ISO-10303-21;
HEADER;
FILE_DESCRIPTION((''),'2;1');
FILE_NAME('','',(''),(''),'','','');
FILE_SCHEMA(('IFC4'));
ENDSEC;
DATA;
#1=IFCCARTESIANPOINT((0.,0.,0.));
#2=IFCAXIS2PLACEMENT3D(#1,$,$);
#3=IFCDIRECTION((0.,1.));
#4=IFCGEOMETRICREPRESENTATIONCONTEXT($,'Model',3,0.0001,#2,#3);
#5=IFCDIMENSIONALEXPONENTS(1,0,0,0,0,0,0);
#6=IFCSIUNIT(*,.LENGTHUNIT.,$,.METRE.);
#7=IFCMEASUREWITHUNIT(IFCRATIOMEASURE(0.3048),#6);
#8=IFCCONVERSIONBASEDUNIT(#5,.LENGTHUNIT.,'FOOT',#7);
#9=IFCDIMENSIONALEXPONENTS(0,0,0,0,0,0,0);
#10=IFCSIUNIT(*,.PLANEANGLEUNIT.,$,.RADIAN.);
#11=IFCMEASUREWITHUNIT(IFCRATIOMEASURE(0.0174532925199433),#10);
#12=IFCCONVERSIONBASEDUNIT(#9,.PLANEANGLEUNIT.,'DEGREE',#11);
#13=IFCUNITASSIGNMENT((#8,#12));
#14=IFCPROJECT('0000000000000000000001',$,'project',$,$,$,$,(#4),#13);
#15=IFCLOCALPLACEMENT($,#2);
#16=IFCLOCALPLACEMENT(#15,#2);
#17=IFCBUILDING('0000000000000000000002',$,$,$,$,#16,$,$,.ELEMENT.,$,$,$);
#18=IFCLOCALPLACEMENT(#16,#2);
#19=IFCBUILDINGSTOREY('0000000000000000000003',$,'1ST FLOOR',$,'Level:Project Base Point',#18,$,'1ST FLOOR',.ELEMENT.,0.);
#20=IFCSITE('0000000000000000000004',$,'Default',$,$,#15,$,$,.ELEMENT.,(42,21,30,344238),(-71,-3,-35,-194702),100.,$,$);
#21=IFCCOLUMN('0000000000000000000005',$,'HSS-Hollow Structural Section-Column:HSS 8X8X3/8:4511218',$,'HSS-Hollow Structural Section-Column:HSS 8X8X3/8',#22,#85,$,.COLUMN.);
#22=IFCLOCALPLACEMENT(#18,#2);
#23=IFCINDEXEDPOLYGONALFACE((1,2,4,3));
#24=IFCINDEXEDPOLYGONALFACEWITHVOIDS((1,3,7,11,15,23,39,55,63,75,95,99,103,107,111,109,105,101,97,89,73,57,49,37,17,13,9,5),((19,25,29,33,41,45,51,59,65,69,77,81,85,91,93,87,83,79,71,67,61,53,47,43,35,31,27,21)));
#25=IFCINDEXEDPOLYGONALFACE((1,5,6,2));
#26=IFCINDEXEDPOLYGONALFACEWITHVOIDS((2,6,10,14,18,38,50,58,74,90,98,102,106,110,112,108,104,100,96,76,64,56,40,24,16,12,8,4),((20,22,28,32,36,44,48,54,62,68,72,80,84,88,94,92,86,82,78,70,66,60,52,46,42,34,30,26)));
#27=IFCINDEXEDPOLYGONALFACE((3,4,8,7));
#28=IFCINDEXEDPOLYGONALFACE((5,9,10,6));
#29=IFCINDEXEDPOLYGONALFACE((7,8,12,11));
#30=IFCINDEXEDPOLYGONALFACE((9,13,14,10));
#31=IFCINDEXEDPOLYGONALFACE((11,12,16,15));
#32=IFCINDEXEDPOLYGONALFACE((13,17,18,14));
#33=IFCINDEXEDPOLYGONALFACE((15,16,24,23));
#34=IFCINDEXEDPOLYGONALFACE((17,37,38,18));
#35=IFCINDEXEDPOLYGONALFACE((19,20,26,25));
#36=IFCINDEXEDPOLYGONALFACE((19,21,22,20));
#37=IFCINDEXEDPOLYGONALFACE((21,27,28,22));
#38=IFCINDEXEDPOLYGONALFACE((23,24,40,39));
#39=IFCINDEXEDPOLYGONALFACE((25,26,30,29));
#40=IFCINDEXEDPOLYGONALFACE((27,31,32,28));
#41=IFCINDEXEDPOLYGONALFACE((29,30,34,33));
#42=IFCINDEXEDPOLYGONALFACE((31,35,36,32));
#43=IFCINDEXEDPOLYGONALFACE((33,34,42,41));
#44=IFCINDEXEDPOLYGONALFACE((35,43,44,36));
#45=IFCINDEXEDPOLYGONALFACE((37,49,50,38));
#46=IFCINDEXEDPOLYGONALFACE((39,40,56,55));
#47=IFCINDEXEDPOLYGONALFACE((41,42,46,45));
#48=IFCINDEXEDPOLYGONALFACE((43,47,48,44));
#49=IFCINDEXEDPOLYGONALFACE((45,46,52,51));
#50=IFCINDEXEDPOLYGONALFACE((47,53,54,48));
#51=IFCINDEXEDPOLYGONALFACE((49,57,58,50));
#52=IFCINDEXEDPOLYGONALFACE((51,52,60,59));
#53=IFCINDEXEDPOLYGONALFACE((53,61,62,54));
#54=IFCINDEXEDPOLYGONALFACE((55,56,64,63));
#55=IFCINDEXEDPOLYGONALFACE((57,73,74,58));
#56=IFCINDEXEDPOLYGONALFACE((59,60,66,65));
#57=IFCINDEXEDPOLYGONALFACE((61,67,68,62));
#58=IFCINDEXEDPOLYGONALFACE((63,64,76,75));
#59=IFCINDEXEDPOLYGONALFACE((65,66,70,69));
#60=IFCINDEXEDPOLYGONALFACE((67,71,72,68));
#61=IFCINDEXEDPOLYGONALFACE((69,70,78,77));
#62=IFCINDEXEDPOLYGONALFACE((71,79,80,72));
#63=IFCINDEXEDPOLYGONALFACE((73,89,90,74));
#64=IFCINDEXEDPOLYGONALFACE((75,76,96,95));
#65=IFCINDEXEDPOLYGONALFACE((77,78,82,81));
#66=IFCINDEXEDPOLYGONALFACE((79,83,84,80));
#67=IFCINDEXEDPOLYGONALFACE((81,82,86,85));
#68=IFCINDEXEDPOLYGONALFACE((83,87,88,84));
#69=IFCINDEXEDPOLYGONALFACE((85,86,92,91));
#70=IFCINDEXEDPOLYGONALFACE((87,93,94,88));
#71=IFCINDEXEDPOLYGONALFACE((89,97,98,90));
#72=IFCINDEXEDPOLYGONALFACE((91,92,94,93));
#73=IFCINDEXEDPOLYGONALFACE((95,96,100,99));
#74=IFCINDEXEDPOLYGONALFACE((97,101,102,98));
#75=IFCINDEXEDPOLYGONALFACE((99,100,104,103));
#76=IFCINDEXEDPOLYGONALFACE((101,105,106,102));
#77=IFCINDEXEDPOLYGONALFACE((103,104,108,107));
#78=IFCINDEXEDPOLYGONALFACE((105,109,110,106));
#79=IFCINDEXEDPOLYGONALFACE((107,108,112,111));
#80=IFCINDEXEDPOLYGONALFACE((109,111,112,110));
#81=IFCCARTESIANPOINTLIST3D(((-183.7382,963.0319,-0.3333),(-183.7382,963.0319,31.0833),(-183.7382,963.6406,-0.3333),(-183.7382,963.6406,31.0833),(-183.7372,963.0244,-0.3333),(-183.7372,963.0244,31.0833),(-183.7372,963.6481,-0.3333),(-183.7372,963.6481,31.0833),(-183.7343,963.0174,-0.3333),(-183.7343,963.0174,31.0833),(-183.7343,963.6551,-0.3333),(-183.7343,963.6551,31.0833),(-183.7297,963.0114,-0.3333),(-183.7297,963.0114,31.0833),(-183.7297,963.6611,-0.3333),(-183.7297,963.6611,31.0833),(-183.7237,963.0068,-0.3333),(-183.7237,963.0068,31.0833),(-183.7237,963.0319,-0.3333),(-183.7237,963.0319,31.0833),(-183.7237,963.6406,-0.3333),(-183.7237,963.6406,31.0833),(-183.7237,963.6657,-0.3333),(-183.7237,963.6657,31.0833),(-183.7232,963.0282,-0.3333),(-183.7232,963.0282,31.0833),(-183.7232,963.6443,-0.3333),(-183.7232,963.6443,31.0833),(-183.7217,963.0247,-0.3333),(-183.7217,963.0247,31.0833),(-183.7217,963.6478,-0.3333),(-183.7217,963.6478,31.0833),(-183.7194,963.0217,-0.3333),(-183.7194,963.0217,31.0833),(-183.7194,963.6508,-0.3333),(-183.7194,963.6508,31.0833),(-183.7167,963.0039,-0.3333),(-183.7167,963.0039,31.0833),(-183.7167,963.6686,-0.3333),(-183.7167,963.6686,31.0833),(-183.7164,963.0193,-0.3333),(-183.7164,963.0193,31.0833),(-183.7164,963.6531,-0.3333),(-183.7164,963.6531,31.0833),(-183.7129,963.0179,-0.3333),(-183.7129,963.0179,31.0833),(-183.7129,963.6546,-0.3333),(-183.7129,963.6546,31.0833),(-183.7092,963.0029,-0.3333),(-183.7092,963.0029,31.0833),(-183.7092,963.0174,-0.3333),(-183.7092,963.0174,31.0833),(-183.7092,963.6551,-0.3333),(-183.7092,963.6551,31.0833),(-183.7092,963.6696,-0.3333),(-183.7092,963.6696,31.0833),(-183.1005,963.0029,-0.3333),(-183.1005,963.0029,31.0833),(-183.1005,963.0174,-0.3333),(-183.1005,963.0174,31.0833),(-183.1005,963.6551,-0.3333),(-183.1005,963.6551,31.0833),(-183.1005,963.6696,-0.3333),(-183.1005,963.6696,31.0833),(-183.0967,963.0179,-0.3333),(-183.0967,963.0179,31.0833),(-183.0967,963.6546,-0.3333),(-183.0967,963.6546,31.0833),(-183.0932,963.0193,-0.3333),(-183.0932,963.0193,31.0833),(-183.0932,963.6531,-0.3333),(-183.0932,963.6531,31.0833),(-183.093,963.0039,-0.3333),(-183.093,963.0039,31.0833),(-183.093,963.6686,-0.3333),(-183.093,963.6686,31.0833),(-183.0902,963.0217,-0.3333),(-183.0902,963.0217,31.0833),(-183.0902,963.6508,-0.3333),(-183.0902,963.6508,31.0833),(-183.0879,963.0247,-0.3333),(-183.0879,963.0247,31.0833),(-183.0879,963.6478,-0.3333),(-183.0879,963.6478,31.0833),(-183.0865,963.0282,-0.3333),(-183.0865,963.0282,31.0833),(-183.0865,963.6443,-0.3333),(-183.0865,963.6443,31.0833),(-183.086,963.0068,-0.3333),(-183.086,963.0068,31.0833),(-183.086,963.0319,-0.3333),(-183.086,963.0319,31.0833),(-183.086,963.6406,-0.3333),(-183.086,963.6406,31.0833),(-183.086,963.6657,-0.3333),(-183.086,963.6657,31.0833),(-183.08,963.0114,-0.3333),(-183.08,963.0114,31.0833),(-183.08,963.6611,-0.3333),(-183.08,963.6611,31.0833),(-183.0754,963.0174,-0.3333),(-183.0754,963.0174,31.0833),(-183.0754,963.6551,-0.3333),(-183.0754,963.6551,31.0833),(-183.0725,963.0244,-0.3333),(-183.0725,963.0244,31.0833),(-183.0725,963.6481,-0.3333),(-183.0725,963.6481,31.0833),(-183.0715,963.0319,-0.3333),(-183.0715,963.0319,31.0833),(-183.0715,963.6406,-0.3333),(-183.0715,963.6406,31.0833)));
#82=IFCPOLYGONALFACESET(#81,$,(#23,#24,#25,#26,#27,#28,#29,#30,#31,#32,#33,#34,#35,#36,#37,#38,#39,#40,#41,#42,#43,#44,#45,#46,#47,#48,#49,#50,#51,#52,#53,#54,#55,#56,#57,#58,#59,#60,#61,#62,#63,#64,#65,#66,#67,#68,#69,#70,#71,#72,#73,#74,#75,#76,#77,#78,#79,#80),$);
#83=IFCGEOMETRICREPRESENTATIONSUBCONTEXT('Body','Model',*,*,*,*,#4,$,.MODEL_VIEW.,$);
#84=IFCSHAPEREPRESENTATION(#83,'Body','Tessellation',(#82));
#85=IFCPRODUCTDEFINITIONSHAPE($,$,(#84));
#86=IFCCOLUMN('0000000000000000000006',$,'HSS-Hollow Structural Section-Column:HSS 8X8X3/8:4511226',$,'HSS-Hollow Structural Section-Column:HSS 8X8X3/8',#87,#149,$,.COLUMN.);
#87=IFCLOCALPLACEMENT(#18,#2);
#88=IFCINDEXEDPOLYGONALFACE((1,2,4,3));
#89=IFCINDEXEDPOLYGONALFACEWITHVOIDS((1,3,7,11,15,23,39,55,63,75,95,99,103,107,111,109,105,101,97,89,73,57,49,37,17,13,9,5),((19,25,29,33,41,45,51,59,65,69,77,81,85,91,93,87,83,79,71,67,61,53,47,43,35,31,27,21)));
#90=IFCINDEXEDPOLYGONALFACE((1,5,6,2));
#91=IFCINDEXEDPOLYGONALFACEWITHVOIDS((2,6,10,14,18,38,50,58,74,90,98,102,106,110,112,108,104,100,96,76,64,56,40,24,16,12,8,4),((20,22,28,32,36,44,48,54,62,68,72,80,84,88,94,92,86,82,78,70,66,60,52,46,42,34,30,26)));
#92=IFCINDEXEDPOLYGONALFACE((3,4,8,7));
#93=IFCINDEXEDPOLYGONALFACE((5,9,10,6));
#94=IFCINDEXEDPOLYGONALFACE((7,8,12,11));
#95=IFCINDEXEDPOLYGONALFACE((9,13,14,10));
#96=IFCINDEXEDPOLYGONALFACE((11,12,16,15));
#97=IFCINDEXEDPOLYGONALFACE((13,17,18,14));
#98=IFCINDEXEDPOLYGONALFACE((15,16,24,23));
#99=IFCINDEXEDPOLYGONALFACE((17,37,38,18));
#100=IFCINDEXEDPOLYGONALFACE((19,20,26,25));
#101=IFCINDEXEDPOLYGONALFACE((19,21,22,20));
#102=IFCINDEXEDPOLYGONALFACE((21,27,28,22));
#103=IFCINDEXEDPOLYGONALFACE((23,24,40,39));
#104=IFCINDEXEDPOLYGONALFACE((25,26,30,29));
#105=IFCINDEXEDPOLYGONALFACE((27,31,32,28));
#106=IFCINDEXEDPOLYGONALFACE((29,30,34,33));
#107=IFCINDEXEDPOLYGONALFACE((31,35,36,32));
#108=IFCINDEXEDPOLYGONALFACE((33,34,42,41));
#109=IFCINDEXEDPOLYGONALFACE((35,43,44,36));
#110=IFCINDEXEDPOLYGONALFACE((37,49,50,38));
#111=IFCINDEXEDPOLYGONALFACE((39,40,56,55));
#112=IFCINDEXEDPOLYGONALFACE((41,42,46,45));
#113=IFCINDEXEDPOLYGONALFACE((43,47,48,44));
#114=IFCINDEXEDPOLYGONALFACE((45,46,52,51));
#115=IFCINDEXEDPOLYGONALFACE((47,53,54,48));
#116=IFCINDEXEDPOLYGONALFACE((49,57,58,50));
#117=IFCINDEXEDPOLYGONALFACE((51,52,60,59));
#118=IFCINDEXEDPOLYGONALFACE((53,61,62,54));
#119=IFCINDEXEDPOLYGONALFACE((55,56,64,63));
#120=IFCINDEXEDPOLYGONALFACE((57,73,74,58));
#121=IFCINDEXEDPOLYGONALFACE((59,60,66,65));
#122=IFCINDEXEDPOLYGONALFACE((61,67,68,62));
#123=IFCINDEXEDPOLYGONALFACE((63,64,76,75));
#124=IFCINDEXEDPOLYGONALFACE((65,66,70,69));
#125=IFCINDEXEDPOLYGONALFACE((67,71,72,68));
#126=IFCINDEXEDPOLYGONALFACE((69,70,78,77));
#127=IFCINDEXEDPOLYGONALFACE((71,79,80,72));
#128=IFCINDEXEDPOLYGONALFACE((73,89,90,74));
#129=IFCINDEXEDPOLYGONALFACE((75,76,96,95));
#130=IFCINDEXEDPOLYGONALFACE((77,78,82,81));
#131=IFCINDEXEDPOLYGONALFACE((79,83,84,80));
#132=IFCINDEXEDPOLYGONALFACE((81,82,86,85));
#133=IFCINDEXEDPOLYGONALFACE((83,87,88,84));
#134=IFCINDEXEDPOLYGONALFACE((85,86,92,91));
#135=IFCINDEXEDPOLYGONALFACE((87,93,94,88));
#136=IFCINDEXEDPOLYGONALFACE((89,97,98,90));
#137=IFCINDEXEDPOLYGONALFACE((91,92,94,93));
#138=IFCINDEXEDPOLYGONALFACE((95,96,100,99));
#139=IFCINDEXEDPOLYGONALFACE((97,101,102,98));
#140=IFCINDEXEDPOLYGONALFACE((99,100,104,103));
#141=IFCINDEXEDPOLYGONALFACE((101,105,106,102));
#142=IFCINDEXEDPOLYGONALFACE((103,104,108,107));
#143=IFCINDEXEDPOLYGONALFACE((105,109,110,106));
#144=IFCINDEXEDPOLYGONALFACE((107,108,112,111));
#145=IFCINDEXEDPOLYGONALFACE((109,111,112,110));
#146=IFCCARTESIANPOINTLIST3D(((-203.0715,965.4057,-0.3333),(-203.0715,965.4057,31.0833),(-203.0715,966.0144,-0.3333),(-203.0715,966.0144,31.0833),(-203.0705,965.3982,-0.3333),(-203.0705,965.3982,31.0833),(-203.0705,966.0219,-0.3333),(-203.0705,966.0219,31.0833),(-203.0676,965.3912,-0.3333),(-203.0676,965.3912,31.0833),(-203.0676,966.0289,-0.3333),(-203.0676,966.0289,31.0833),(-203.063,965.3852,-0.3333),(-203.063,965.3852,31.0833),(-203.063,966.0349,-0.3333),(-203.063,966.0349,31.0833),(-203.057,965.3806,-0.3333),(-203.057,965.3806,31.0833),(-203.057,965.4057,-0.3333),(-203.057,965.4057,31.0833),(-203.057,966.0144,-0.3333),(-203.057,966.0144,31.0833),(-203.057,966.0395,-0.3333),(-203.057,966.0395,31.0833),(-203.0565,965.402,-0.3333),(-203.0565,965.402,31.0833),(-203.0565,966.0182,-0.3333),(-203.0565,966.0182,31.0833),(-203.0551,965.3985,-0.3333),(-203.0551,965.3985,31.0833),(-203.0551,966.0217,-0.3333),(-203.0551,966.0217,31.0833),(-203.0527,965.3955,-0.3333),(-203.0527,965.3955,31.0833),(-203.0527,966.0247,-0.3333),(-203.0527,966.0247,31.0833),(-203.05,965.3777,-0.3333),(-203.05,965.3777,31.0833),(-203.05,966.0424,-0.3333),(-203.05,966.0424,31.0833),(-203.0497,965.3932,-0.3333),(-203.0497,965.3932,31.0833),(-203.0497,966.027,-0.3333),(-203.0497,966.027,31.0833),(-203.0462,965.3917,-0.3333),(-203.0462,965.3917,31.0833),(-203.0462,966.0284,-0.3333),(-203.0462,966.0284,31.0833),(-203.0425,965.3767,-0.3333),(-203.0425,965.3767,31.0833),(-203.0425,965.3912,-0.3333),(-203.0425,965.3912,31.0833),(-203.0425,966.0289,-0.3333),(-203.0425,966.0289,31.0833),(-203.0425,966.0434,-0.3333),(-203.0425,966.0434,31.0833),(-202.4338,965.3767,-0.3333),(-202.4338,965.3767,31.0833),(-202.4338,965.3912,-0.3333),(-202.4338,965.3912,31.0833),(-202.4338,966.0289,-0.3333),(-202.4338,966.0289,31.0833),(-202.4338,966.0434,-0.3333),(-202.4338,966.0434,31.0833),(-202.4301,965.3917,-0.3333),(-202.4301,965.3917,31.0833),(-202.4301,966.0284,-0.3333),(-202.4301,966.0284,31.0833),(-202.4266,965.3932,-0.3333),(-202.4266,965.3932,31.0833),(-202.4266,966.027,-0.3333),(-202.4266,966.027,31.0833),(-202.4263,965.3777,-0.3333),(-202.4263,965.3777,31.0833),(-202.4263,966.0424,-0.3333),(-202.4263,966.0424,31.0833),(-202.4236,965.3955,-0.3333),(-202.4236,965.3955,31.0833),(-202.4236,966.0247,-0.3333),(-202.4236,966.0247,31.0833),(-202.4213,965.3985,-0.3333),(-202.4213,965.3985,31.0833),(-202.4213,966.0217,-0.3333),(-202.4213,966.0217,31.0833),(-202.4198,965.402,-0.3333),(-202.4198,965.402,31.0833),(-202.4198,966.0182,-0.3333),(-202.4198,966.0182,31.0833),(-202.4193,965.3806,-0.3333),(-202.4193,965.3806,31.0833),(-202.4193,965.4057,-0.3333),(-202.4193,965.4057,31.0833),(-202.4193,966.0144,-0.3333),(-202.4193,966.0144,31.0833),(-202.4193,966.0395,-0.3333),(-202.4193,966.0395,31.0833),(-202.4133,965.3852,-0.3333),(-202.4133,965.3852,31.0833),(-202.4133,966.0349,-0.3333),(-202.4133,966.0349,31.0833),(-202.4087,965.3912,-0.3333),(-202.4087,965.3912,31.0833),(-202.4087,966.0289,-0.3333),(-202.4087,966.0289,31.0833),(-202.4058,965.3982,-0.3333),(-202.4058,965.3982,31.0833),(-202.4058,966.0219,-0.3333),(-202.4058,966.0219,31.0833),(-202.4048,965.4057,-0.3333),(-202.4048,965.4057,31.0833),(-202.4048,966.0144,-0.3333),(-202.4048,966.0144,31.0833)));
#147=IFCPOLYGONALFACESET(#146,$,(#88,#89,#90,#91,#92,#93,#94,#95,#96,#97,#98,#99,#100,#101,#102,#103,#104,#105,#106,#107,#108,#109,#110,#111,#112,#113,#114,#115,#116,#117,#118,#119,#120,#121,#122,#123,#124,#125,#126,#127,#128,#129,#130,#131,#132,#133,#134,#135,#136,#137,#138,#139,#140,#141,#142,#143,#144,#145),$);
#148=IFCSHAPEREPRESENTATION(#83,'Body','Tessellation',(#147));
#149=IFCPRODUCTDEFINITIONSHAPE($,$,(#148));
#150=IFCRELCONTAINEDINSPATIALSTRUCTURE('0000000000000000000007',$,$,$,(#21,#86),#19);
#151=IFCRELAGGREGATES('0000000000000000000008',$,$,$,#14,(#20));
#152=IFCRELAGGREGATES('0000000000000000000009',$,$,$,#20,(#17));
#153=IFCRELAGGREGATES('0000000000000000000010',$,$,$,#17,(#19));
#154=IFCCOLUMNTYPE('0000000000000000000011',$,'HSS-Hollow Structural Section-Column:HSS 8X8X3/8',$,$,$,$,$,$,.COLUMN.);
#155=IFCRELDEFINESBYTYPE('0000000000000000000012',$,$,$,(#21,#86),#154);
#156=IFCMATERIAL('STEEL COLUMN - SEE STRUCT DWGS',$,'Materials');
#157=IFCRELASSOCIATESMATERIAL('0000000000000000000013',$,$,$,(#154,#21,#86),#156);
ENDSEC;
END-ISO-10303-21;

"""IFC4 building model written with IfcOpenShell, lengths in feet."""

from ifc_helpers import new_model, entity, si_unit, converted_unit, direction, frame, frame_2d, origin, place, context, subcontext, project, spatial, polyline, circle_curve, parameter, trimmed, segment, composite_curve, outline, extrude, source, transform, mapped, material, material_profile, profile_set, profile_usage, type_object, type_shapes, element, save


model = new_model("IFC4")

# Units and contexts
model_context = context("Model", 3, precision=0.0001, world=origin(), true_north=direction((0.0, 1.0)))
body_context = subcontext(model_context, "Body", "Model", "MODEL_VIEW")
ifc_project = project(units=[converted_unit("LENGTHUNIT", "FOOT", entity("IfcRatioMeasure", 0.3048), si_unit("LENGTHUNIT", "METRE"), dimensions=[1, 0, 0, 0, 0, 0, 0]), converted_unit("PLANEANGLEUNIT", "DEGREE", entity("IfcRatioMeasure", 0.0174532925199433), si_unit("PLANEANGLEUNIT", "RADIAN"), dimensions=[0, 0, 0, 0, 0, 0, 0])], contexts=[model_context])

# Site, building, storey
site_placement = place(None, origin())
site = spatial("IfcSite", under=ifc_project, at=site_placement, Name="Default", CompositionType="ELEMENT", RefLatitude=(42, 21, 30, 344238), RefLongitude=(-71, -3, -35, -194702), RefElevation=100.0)
building_placement = place(site_placement, origin())
building = spatial("IfcBuilding", under=site, at=building_placement, CompositionType="ELEMENT")
storey_placement = place(building_placement, origin())
storey = spatial("IfcBuildingStorey", under=building, at=storey_placement, Name="1ST FLOOR", ObjectType="Level:Project Base Point", LongName="1ST FLOOR", CompositionType="ELEMENT", Elevation=0.0)

# Columns
ifc_material_1 = material(Name="STEEL COLUMN - SEE STRUCT DWGS", Category="Materials")
ifc_material_profile = material_profile(ifc_material_1, outline(composite_curve([segment(polyline([(-0.3043, -0.3333), (0.3043, -0.3333)]), True, "CONTINUOUS"), segment(trimmed(circle_curve(frame_2d((0.3043, -0.3043), x_axis=(-1.0, 0.0)), 0.029), [parameter(90.0)], [parameter(180.0)], True, "PARAMETER"), True, "CONTINUOUS"), segment(polyline([(0.3333, -0.3043), (0.3333, 0.3043)]), True, "CONTINUOUS"), segment(trimmed(circle_curve(frame_2d((0.3043, 0.3043), x_axis=(-1.0, 0.0)), 0.029), [parameter(180.0)], [parameter(270.0)], True, "PARAMETER"), True, "CONTINUOUS"), segment(polyline([(0.3043, 0.3333), (-0.3043, 0.3333)]), True, "CONTINUOUS"), segment(trimmed(circle_curve(frame_2d((-0.3043, 0.3043), x_axis=(-1.0, 0.0)), 0.029), [parameter(270.0)], [parameter(360.0)], True, "PARAMETER"), True, "CONTINUOUS"), segment(polyline([(-0.3333, 0.3043), (-0.3333, -0.3043)]), True, "CONTINUOUS"), segment(trimmed(circle_curve(frame_2d((-0.3043, -0.3043), x_axis=(-1.0, 0.0)), 0.029), [parameter(360.0)], [parameter(90.0)], True, "PARAMETER"), True, "CONTINUOUS")], self_intersect=False), holes=[composite_curve([segment(trimmed(circle_curve(frame_2d((-0.3043, -0.3043), x_axis=(-1.0, 0.0)), 0.0145), [parameter(0.0)], [parameter(90.0)], True, "PARAMETER"), False, "CONTINUOUS"), segment(polyline([(-0.3188, -0.3043), (-0.3188, 0.3043)]), True, "CONTINUOUS"), segment(trimmed(circle_curve(frame_2d((-0.3043, 0.3043), x_axis=(-1.0, 0.0)), 0.0145), [parameter(270.0)], [parameter(0.0)], True, "PARAMETER"), False, "CONTINUOUS"), segment(polyline([(-0.3043, 0.3188), (0.3043, 0.3188)]), True, "CONTINUOUS"), segment(trimmed(circle_curve(frame_2d((0.3043, 0.3043), x_axis=(-1.0, 0.0)), 0.0145), [parameter(180.0)], [parameter(270.0)], True, "PARAMETER"), False, "CONTINUOUS"), segment(polyline([(0.3188, 0.3043), (0.3188, -0.3043)]), True, "CONTINUOUS"), segment(trimmed(circle_curve(frame_2d((0.3043, -0.3043), x_axis=(-1.0, 0.0)), 0.0145), [parameter(90.0)], [parameter(180.0)], True, "PARAMETER"), False, "CONTINUOUS"), segment(polyline([(0.3043, -0.3188), (-0.3043, -0.3188)]), True, "CONTINUOUS")], self_intersect=False)]), Name="HSS 8X8X3/8")
ifc_profile_set = profile_set([ifc_material_profile], Name="HSS 8X8X3/8")
ifc_profile_usage_1 = profile_usage(ifc_profile_set)
column_type = type_object("IfcColumnType", Name="HSS-Hollow Structural Section-Column:HSS 8X8X3/8", PredefinedType="COLUMN", material=ifc_profile_set)
shared_shape_1 = source(origin(), body_context, "Body", "SweptSolid", [
    extrude(outline(composite_curve([segment(trimmed(circle_curve(frame_2d((0.3043, -0.3043), x_axis=(1.0, 0.0)), 0.029), [parameter(270.0)], [parameter(0.0)], True, "PARAMETER"), True, "CONTINUOUS"), segment(polyline([(0.3333, -0.3043), (0.3333, 0.3043)]), True, "CONTINUOUS"), segment(trimmed(circle_curve(frame_2d((0.3043, 0.3043), x_axis=(1.0, 0.0)), 0.029), [parameter(0.0)], [parameter(90.0)], True, "PARAMETER"), True, "CONTINUOUS"), segment(polyline([(0.3043, 0.3333), (-0.3043, 0.3333)]), True, "CONTINUOUS"), segment(trimmed(circle_curve(frame_2d((-0.3043, 0.3043), x_axis=(1.0, 0.0)), 0.029), [parameter(90.0)], [parameter(180.0)], True, "PARAMETER"), True, "CONTINUOUS"), segment(polyline([(-0.3333, 0.3043), (-0.3333, -0.3043)]), True, "CONTINUOUS"), segment(trimmed(circle_curve(frame_2d((-0.3043, -0.3043), x_axis=(1.0, 0.0)), 0.029), [parameter(180.0)], [parameter(270.0)], True, "PARAMETER"), True, "CONTINUOUS"), segment(polyline([(-0.3043, -0.3333), (0.3043, -0.3333)]), True, "CONTINUOUS")], self_intersect=False), holes=[composite_curve([segment(polyline([(0.3043, -0.3188), (-0.3043, -0.3188)]), True, "CONTINUOUS"), segment(trimmed(circle_curve(frame_2d((-0.3043, -0.3043), x_axis=(1.0, 0.0)), 0.0145), [parameter(180.0)], [parameter(270.0)], True, "PARAMETER"), False, "CONTINUOUS"), segment(polyline([(-0.3188, -0.3043), (-0.3188, 0.3043)]), True, "CONTINUOUS"), segment(trimmed(circle_curve(frame_2d((-0.3043, 0.3043), x_axis=(1.0, 0.0)), 0.0145), [parameter(90.0)], [parameter(180.0)], True, "PARAMETER"), False, "CONTINUOUS"), segment(polyline([(-0.3043, 0.3188), (0.3043, 0.3188)]), True, "CONTINUOUS"), segment(trimmed(circle_curve(frame_2d((0.3043, 0.3043), x_axis=(1.0, 0.0)), 0.0145), [parameter(0.0)], [parameter(90.0)], True, "PARAMETER"), False, "CONTINUOUS"), segment(polyline([(0.3188, 0.3043), (0.3188, -0.3043)]), True, "CONTINUOUS"), segment(trimmed(circle_curve(frame_2d((0.3043, -0.3043), x_axis=(1.0, 0.0)), 0.0145), [parameter(270.0)], [parameter(0.0)], True, "PARAMETER"), False, "CONTINUOUS")], self_intersect=False)]), frame((0.0, 0.0, -0.3333)), (0.0, 0.0, 1.0), 31.4167),
])
type_shapes(column_type, [shared_shape_1])
column_1_placement = place(storey_placement, frame((-183.4048, 963.3362, 0.0), z_axis=(0.0, 0.0, 1.0), x_axis=(-1.0, 0.0, 0.0)))
element("IfcColumn", 1, at=column_1_placement, inside=storey, type_object=column_type, material=ifc_profile_usage_1, Name="HSS-Hollow Structural Section-Column:HSS 8X8X3/8:4511218", ObjectType="HSS-Hollow Structural Section-Column:HSS 8X8X3/8", PredefinedType="COLUMN", context=body_context, shape_type="MappedRepresentation", body=[
    mapped(shared_shape_1, transform((0.0, 0.0, 0.0), scale=1.0)),
])
ifc_profile_usage_2 = profile_usage(ifc_profile_set)
column_2_placement = place(storey_placement, frame((-202.7382, 965.7101, 0.0), z_axis=(0.0, 0.0, 1.0), x_axis=(-1.0, 0.0, 0.0)))
element("IfcColumn", 2, at=column_2_placement, inside=storey, type_object=column_type, material=ifc_profile_usage_2, Name="HSS-Hollow Structural Section-Column:HSS 8X8X3/8:4511226", ObjectType="HSS-Hollow Structural Section-Column:HSS 8X8X3/8", PredefinedType="COLUMN", context=body_context, shape_type="MappedRepresentation", body=[
    mapped(shared_shape_1, transform((0.0, 0.0, 0.0), scale=1.0)),
])

save(model, "model.ifc")
